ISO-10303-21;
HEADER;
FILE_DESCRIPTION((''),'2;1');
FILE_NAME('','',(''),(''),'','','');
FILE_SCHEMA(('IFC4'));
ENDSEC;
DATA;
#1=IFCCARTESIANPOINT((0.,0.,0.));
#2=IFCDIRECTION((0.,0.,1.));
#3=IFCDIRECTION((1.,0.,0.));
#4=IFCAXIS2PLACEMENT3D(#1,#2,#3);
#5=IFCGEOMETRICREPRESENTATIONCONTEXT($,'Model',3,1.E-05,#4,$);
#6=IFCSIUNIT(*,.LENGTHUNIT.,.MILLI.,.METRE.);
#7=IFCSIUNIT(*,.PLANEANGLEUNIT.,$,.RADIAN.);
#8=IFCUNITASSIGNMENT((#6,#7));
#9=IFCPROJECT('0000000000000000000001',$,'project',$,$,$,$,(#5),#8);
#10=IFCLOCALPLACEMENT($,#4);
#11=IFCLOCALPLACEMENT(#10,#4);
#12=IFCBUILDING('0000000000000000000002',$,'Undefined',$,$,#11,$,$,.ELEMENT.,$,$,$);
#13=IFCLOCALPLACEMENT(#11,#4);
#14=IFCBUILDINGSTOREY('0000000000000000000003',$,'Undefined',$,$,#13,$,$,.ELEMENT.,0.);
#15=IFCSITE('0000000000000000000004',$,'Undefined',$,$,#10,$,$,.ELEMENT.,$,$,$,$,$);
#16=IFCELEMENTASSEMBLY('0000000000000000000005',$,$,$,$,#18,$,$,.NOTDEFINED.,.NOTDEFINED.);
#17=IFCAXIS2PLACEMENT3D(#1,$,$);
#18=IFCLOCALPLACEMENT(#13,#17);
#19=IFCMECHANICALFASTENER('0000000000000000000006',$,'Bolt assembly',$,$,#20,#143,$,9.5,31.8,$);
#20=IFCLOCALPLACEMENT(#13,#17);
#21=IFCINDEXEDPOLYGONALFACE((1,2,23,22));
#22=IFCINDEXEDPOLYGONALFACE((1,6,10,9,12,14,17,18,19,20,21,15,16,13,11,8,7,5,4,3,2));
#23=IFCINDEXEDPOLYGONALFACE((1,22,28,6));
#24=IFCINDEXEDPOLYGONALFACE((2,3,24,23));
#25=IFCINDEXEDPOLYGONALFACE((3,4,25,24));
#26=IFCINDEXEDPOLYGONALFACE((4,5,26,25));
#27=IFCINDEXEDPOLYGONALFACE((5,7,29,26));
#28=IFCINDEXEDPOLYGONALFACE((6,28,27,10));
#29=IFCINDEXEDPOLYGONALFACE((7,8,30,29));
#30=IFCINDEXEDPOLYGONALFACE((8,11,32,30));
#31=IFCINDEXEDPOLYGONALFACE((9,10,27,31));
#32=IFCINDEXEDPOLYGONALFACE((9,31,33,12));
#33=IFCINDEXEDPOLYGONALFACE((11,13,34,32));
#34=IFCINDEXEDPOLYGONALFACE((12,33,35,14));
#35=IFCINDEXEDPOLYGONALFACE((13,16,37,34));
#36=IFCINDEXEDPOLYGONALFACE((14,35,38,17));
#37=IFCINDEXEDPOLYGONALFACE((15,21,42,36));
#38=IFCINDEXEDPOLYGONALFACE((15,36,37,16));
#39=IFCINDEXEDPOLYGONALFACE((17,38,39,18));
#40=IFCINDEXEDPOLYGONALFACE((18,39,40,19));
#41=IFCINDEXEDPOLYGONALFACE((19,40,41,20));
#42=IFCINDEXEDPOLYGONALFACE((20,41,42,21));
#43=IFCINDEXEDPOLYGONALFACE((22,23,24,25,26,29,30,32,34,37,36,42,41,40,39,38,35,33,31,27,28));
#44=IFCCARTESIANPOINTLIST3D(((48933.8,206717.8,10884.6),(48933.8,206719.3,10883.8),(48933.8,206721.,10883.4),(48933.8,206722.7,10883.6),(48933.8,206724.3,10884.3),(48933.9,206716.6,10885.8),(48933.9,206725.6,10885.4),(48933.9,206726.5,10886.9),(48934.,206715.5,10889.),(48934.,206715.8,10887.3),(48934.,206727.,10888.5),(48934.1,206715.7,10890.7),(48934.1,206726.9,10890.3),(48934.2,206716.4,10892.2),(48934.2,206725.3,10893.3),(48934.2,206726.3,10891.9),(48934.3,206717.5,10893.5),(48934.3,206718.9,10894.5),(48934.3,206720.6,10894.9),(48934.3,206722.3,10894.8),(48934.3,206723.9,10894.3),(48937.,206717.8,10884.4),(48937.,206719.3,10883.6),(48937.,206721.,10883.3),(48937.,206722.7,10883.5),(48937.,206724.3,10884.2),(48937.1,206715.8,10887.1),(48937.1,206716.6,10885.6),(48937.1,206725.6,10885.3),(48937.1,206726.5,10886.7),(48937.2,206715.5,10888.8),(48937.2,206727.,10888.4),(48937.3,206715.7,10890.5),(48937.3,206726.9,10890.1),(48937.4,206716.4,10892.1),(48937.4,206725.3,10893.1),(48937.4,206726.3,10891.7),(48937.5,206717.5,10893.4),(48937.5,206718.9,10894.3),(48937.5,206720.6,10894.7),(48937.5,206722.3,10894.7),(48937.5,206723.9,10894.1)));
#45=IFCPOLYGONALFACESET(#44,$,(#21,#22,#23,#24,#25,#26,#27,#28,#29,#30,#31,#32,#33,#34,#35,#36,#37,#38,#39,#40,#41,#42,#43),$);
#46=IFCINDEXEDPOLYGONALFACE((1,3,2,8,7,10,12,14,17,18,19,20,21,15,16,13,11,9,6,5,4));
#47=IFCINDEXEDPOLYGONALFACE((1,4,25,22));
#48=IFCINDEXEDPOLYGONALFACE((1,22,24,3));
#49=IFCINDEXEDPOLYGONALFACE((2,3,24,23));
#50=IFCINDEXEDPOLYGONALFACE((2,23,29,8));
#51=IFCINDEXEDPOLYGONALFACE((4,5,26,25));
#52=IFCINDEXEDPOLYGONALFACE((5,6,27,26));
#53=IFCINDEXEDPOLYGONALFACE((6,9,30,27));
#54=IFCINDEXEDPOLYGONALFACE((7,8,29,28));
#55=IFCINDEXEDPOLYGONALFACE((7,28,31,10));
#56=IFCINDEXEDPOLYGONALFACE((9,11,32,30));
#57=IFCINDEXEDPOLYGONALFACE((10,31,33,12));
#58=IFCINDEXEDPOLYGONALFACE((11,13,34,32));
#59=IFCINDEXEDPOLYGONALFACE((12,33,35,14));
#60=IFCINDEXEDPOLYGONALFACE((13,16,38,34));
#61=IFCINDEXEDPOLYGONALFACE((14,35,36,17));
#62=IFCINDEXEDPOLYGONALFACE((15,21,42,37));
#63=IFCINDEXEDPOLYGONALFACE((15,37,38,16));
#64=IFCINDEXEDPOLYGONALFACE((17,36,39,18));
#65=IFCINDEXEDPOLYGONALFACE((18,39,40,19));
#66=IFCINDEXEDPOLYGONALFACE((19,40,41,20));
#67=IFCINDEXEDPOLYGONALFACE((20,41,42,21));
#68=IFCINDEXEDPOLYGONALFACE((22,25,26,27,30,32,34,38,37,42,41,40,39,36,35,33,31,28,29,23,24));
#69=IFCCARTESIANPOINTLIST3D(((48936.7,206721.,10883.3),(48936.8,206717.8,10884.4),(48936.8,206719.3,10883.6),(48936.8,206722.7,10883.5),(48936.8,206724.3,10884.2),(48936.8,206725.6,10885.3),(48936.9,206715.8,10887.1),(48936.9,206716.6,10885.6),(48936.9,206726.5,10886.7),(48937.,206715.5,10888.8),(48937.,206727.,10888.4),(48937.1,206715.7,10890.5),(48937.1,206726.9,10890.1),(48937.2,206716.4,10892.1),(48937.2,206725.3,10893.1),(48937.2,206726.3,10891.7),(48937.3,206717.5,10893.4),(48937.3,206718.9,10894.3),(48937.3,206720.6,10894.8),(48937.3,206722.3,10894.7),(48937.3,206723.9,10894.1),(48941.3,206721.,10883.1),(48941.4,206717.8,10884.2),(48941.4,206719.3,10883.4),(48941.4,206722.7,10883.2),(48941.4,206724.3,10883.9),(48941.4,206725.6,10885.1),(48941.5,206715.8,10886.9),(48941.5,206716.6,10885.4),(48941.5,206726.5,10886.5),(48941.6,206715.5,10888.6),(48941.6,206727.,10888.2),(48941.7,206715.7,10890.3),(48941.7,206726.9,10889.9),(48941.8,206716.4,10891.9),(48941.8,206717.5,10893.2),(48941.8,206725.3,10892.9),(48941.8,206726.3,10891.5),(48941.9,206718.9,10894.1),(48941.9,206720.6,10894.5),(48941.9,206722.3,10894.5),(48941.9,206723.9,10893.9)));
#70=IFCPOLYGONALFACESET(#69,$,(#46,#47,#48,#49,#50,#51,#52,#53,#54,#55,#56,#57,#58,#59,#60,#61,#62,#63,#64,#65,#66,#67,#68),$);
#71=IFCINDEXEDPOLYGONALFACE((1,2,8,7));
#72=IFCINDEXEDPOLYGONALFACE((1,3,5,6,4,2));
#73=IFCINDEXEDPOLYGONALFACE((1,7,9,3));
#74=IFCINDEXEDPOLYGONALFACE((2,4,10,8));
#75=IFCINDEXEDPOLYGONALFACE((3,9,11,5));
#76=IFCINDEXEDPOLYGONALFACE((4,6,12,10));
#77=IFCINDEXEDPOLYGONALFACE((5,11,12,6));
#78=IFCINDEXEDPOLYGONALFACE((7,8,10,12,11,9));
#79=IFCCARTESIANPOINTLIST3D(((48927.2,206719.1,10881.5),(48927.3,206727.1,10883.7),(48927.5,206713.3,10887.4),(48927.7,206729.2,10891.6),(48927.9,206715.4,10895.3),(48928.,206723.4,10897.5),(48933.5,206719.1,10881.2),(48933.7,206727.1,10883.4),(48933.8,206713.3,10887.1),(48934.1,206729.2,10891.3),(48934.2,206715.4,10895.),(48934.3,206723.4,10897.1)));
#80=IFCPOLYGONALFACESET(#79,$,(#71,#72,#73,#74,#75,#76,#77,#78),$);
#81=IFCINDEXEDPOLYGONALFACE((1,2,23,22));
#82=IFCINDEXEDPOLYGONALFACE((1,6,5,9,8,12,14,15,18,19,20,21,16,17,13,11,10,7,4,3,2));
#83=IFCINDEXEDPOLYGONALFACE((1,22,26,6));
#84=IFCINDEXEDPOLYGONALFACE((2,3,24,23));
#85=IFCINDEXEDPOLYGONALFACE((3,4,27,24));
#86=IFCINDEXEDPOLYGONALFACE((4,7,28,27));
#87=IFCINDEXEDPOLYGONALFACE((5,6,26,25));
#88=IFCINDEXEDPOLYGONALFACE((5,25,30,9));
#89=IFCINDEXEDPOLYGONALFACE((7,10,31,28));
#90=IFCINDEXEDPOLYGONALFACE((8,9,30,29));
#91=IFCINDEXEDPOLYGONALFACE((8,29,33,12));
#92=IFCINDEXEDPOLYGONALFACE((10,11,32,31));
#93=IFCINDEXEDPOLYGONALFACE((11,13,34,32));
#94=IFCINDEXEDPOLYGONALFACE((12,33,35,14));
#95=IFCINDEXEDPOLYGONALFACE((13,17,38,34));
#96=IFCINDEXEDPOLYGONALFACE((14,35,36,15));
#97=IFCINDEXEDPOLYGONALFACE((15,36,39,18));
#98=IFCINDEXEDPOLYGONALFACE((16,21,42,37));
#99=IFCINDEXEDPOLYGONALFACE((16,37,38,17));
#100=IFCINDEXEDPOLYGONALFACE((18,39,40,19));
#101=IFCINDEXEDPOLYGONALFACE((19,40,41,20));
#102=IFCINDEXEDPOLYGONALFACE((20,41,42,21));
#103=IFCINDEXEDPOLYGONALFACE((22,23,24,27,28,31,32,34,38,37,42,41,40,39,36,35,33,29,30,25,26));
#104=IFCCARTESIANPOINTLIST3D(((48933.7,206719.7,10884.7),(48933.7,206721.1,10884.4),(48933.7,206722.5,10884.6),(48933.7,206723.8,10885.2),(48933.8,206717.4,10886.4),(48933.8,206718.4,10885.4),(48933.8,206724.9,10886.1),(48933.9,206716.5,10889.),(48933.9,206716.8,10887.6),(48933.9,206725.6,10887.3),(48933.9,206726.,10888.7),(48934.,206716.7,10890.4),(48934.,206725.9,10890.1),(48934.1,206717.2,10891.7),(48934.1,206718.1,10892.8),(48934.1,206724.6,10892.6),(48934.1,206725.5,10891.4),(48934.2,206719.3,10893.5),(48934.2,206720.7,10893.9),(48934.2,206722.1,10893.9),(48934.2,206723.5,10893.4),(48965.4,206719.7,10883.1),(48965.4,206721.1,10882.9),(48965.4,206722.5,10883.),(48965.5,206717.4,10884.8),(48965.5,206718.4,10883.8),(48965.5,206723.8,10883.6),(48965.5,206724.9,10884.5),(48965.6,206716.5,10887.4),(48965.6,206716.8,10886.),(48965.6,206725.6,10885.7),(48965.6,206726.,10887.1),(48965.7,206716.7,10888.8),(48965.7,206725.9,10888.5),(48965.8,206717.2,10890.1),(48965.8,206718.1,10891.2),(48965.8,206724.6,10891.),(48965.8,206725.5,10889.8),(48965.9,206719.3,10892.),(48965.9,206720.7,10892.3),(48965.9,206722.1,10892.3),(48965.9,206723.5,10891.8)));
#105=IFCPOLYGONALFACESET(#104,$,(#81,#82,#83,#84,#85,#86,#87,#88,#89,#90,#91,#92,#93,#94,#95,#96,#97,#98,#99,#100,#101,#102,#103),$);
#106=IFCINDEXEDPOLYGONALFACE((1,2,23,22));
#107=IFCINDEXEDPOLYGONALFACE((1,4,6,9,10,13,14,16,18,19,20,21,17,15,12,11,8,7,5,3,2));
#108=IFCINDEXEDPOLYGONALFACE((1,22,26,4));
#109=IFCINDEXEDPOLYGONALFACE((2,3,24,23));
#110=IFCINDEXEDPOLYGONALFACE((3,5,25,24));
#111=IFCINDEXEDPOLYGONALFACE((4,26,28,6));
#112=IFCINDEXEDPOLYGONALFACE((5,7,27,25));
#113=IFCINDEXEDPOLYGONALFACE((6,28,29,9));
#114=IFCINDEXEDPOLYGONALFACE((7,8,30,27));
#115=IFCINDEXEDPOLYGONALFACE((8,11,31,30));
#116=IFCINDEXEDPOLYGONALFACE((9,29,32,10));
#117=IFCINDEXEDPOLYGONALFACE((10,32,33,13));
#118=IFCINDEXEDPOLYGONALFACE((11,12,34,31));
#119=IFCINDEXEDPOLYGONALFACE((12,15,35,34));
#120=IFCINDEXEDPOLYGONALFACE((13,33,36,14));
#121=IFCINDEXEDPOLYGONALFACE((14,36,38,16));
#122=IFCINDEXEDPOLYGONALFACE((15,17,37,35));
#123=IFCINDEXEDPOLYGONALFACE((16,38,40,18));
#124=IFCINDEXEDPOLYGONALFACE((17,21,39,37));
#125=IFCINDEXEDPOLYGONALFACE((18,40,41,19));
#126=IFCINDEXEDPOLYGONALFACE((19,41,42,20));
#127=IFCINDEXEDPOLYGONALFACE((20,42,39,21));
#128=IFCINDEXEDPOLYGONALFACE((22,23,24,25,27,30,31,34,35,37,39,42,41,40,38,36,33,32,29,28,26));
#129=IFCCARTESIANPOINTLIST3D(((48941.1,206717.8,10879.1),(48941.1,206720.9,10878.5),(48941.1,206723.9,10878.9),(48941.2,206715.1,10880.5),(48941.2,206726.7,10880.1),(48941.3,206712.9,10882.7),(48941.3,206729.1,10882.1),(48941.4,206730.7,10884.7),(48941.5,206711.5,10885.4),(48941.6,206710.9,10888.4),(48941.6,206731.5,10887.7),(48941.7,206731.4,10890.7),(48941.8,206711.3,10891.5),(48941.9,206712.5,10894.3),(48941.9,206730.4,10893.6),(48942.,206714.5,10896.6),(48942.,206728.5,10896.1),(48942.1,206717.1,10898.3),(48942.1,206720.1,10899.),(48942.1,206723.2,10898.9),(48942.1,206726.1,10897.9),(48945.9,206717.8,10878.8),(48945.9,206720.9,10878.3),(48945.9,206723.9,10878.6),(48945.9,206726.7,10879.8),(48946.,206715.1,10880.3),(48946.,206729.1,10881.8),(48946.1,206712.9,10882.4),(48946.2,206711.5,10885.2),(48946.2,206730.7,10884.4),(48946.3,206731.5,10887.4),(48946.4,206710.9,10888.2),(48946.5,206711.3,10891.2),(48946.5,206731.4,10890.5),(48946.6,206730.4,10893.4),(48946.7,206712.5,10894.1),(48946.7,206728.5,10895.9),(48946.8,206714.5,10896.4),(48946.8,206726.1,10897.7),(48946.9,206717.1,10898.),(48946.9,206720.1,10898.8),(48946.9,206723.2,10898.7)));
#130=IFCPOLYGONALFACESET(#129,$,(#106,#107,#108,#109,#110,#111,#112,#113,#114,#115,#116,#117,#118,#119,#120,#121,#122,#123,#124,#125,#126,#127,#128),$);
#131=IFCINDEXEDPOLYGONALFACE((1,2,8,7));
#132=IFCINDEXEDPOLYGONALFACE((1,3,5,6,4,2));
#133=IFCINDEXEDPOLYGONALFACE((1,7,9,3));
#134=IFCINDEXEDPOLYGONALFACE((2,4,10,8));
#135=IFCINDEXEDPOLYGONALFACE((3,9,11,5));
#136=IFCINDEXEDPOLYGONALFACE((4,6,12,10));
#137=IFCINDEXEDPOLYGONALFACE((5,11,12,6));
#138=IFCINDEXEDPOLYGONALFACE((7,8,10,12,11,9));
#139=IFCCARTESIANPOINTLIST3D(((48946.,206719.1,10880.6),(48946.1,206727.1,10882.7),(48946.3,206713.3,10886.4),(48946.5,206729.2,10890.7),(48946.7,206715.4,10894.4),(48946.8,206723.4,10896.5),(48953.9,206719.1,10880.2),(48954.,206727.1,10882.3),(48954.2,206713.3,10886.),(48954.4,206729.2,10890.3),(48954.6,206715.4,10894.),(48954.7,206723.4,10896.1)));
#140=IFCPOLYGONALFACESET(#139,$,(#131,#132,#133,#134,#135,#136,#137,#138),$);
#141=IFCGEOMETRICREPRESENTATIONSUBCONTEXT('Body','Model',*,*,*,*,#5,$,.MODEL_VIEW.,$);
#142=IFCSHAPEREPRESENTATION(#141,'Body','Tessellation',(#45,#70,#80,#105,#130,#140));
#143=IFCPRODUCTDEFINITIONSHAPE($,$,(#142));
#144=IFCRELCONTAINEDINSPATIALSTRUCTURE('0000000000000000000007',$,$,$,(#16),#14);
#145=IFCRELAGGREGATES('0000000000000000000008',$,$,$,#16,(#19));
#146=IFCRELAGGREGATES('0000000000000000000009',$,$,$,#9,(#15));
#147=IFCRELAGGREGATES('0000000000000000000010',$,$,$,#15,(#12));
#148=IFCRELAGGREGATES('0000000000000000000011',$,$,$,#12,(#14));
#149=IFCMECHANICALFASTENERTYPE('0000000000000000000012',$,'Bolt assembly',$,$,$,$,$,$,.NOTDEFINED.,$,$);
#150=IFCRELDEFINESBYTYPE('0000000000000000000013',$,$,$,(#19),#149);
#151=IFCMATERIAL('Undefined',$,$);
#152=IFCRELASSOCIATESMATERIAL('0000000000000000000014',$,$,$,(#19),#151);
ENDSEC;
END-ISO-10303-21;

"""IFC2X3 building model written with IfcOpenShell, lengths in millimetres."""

from ifc_helpers import new_model, si_unit, frame, origin_with_axes, origin_2d_with_axis, place, context, subcontext, project, spatial, polyline, circle, outline, extrude, source, transform, mapped, material, type_object, element, aggregate, save


model = new_model("IFC2X3")

# Units and contexts
model_context = context("Model", 3, precision=1e-05, world=origin_with_axes())
body_context = subcontext(model_context, "Body", "Model", "MODEL_VIEW")
ifc_project = project(units=[si_unit("LENGTHUNIT", "METRE", prefix="MILLI"), si_unit("PLANEANGLEUNIT", "RADIAN")], contexts=[model_context])

# Site, building, storey
site_placement = place(None, origin_with_axes())
site = spatial("IfcSite", under=ifc_project, at=site_placement, Name="Undefined", CompositionType="ELEMENT")
building_placement = place(site_placement, origin_with_axes())
building = spatial("IfcBuilding", under=site, at=building_placement, Name="Undefined", CompositionType="ELEMENT")
storey_placement = place(building_placement, origin_with_axes())
storey = spatial("IfcBuildingStorey", under=building, at=storey_placement, Name="Undefined", CompositionType="ELEMENT", Elevation=0.0)

# Element assembly
assembly_1_placement = place(storey_placement, origin_with_axes())
assembly_1 = element("IfcElementAssembly", 1, at=assembly_1_placement, inside=storey, AssemblyPlace="NOTDEFINED", PredefinedType="NOTDEFINED")

# Shared definitions
ifc_material_1 = material(Name="Undefined")
mechanical_fastener_type = type_object("IfcMechanicalFastenerType", Name="Bolt assembly")

# Mechanical fastener
shared_shape_1 = source(origin_with_axes(), body_context, "Body", "SweptSolid", [
    extrude(circle(Radius=5.8, at=origin_2d_with_axis()), frame((0.0, -7.6, 0.0), z_axis=(0.0, 1.0, 0.0), x_axis=(1.0, 0.0, 0.0)), (0.0, 0.0, 1.0), 3.2),
    extrude(circle(Radius=5.8, at=origin_2d_with_axis()), frame((0.0, -4.6, 0.0), z_axis=(0.0, 1.0, 0.0), x_axis=(1.0, 0.0, 0.0)), (0.0, 0.0, 1.0), 4.6),
    extrude(outline(polyline([(7.1, -4.1), (7.1, 4.1), (0.0, 8.2), (-7.1, 4.1), (-7.1, -4.1), (0.0, -8.2), (7.1, -4.1)])), frame((0.0, -14.0, 0.0), z_axis=(0.0, 1.0, 0.0), x_axis=(1.0, 0.0, 0.0)), (0.0, 0.0, 1.0), 6.3),
    extrude(circle(Radius=4.8, at=origin_2d_with_axis()), frame((0.0, -7.7, 0.0), z_axis=(0.0, 1.0, 0.0), x_axis=(1.0, 0.0, 0.0)), (0.0, 0.0, 1.0), 31.8),
    extrude(circle(Radius=10.3, at=origin_2d_with_axis()), frame((0.0, 0.0, 0.0), z_axis=(0.0, 1.0, 0.0), x_axis=(1.0, 0.0, 0.0)), (0.0, 0.0, 1.0), 4.8),
    extrude(outline(polyline([(7.1, -4.1), (7.1, 4.1), (0.0, 8.2), (-7.1, 4.1), (-7.1, -4.1), (0.0, -8.2), (7.1, -4.1)])), frame((0.0, 4.8, 0.0), z_axis=(0.0, 1.0, 0.0), x_axis=(1.0, 0.0, 0.0)), (0.0, 0.0, 1.0), 7.9),
])
mechanical_fastener_1_placement = place(assembly_1_placement, frame((48941.6, 206721.2, 10888.8), z_axis=(-0.035281, 0.707107, -0.706226), x_axis=(0.035282, 0.707107, 0.706226)))
mechanical_fastener_1 = element("IfcMechanicalFastener", 2, at=mechanical_fastener_1_placement, type_object=mechanical_fastener_type, material=ifc_material_1, Name="Bolt assembly", NominalDiameter=9.5, NominalLength=31.8, context=body_context, shape_type="MappedRepresentation", body=[
    mapped(shared_shape_1, transform((0.0, 0.0, 0.0))),
])
aggregate(assembly_1, [mechanical_fastener_1])

save(model, "model.ifc")
